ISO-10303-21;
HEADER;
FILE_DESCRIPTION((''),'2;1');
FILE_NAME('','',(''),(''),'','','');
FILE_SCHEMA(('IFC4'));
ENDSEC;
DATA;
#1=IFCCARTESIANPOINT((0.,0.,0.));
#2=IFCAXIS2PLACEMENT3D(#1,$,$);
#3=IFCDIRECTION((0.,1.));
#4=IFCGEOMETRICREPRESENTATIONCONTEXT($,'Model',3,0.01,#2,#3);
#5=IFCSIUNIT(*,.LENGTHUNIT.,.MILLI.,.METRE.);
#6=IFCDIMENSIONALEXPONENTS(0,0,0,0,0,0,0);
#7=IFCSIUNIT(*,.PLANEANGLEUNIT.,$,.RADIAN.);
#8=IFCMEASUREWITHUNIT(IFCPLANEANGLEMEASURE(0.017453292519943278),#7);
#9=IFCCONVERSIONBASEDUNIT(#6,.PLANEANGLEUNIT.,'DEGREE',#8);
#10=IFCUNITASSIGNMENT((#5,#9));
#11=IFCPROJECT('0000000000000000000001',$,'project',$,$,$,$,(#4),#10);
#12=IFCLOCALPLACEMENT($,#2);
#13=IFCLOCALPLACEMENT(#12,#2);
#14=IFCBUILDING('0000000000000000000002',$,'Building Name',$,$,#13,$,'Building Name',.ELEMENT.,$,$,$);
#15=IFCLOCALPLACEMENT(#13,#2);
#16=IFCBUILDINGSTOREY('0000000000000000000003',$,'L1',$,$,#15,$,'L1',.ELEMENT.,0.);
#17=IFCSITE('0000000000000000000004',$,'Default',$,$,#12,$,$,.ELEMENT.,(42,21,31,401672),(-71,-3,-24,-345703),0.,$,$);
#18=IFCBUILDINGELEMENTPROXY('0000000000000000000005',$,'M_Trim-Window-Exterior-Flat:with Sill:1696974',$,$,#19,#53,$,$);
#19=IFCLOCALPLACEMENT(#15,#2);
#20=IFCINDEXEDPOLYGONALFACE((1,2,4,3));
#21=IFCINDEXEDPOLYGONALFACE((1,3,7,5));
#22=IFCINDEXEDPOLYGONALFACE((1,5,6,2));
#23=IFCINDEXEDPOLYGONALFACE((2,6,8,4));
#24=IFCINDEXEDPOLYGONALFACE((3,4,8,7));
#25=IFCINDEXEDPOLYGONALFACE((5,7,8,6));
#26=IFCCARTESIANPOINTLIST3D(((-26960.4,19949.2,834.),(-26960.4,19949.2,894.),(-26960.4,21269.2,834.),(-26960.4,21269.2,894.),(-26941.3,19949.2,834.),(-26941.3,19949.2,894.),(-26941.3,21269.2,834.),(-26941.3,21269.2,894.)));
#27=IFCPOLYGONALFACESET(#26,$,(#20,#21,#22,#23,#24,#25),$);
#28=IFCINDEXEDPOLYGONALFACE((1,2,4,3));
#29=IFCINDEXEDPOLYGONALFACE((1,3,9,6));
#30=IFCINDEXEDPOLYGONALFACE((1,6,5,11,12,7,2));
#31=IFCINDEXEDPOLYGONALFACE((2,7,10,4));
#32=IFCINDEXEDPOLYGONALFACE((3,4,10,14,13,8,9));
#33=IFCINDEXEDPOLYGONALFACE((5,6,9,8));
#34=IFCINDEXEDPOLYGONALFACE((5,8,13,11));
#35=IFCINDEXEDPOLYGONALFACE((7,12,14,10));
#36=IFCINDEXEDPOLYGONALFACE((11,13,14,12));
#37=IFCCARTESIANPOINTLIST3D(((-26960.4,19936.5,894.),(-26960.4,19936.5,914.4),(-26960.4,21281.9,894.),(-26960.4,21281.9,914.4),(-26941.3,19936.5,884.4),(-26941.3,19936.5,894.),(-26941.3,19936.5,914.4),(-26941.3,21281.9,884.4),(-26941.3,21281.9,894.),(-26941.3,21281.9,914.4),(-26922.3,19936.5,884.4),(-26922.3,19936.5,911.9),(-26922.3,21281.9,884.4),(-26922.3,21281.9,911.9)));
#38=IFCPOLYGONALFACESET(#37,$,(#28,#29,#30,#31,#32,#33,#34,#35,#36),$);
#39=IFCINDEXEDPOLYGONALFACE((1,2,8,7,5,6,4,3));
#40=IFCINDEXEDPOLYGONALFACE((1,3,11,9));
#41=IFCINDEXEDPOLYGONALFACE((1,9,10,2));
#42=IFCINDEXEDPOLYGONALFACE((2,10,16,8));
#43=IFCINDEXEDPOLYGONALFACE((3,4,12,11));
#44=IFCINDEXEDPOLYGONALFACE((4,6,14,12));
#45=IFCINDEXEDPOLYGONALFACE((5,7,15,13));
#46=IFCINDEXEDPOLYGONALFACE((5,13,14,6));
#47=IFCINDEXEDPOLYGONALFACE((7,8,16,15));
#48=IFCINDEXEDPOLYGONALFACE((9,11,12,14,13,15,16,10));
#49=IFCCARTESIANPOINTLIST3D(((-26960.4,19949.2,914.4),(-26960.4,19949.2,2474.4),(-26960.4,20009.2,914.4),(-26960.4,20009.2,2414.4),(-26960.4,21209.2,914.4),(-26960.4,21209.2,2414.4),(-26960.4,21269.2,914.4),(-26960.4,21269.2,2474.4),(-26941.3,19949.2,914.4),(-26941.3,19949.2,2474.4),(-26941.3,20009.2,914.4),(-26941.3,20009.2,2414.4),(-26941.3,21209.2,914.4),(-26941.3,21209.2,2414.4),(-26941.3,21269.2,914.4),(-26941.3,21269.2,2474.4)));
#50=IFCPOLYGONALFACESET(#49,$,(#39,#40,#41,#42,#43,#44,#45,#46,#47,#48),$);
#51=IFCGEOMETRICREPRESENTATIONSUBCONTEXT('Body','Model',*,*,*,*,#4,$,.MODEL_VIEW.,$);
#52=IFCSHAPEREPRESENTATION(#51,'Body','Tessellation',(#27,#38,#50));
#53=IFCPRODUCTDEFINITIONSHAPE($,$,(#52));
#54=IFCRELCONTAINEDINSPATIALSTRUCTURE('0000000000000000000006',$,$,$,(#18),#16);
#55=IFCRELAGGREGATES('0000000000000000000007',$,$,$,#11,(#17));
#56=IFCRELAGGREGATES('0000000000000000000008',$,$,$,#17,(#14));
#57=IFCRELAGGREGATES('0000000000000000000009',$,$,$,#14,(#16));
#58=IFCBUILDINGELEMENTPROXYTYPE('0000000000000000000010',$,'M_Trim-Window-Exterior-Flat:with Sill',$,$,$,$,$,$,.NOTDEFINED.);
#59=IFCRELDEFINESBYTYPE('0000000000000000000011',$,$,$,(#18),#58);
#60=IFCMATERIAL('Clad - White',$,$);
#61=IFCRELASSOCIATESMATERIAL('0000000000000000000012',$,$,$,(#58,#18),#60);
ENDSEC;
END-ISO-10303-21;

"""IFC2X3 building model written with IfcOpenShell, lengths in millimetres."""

from ifc_helpers import new_model, entity, si_unit, converted_unit, direction, frame, frame_2d, origin, place, context, subcontext, project, spatial, polyline, rectangle, outline, extrude, source, transform, mapped, material, type_object, type_shapes, element, save


model = new_model("IFC2X3")

# Units and contexts
model_context = context("Model", 3, precision=0.01, world=origin(), true_north=direction((0.0, 1.0)))
body_context = subcontext(model_context, "Body", "Model", "MODEL_VIEW")
ifc_project = project(units=[si_unit("LENGTHUNIT", "METRE", prefix="MILLI"), converted_unit("PLANEANGLEUNIT", "DEGREE", entity("IfcPlaneAngleMeasure", 0.017453292519943278), si_unit("PLANEANGLEUNIT", "RADIAN"), dimensions=[0, 0, 0, 0, 0, 0, 0])], contexts=[model_context])

# Site, building, storey
site_placement = place(None, origin())
site = spatial("IfcSite", under=ifc_project, at=site_placement, Name="Default", CompositionType="ELEMENT", RefLatitude=(42, 21, 31, 401672), RefLongitude=(-71, -3, -24, -345703), RefElevation=0.0)
building_placement = place(site_placement, origin())
building = spatial("IfcBuilding", under=site, at=building_placement, Name="Building Name", LongName="Building Name", CompositionType="ELEMENT")
storey_placement = place(building_placement, origin())
storey = spatial("IfcBuildingStorey", under=building, at=storey_placement, Name="L1", LongName="L1", CompositionType="ELEMENT", Elevation=0.0)

# Shared definitions
ifc_material_1 = material(Name="Clad - White")

# Building element proxy
building_element_proxy_type_1 = type_object("IfcBuildingElementProxyType", Name="M_Trim-Window-Exterior-Flat:with Sill", PredefinedType="NOTDEFINED", material=ifc_material_1)
shared_shape_1 = source(origin(), body_context, "Body", "SweptSolid", [
    extrude(rectangle(XDim=60.0, YDim=1320.0, at=frame_2d((0.0, 0.0), x_axis=(1.0, 0.0))), frame((0.0, 1550.4, 0.0), z_axis=(0.0, 0.0, 1.0), x_axis=(0.0, 1.0, 0.0)), (0.0, 0.0, 1.0), 19.0),
    extrude(outline(polyline([(-15.2, -19.0), (12.3, -19.0), (14.8, 0.0), (14.8, 19.0), (-5.7, 19.0), (-5.7, 0.0), (-15.2, 0.0), (-15.2, -19.0)])), frame((-672.7, 1514.8, 19.0), z_axis=(1.0, 0.0, 0.0), x_axis=(0.0, -1.0, 0.0)), (0.0, 0.0, 1.0), 1345.4),
    extrude(outline(polyline([(-660.0, -795.0), (660.0, -795.0), (660.0, 765.0), (600.0, 765.0), (600.0, -735.0), (-600.0, -735.0), (-600.0, 765.0), (-660.0, 765.0), (-660.0, -795.0)])), frame((0.0, 735.0, 0.0)), (0.0, 0.0, 1.0), 19.0),
])
type_shapes(building_element_proxy_type_1, [shared_shape_1])
proxy_1_placement = place(storey_placement, frame((-26960.4, 20609.2, 2414.4), z_axis=(1.0, 0.0, 0.0), x_axis=(0.0, -1.0, 0.0)))
element("IfcBuildingElementProxy", 1, at=proxy_1_placement, inside=storey, type_object=building_element_proxy_type_1, material=ifc_material_1, Name="M_Trim-Window-Exterior-Flat:with Sill:1696974", context=body_context, shape_type="MappedRepresentation", body=[
    mapped(shared_shape_1, transform((0.0, 0.0, 0.0), scale=1.0)),
])

save(model, "model.ifc")
